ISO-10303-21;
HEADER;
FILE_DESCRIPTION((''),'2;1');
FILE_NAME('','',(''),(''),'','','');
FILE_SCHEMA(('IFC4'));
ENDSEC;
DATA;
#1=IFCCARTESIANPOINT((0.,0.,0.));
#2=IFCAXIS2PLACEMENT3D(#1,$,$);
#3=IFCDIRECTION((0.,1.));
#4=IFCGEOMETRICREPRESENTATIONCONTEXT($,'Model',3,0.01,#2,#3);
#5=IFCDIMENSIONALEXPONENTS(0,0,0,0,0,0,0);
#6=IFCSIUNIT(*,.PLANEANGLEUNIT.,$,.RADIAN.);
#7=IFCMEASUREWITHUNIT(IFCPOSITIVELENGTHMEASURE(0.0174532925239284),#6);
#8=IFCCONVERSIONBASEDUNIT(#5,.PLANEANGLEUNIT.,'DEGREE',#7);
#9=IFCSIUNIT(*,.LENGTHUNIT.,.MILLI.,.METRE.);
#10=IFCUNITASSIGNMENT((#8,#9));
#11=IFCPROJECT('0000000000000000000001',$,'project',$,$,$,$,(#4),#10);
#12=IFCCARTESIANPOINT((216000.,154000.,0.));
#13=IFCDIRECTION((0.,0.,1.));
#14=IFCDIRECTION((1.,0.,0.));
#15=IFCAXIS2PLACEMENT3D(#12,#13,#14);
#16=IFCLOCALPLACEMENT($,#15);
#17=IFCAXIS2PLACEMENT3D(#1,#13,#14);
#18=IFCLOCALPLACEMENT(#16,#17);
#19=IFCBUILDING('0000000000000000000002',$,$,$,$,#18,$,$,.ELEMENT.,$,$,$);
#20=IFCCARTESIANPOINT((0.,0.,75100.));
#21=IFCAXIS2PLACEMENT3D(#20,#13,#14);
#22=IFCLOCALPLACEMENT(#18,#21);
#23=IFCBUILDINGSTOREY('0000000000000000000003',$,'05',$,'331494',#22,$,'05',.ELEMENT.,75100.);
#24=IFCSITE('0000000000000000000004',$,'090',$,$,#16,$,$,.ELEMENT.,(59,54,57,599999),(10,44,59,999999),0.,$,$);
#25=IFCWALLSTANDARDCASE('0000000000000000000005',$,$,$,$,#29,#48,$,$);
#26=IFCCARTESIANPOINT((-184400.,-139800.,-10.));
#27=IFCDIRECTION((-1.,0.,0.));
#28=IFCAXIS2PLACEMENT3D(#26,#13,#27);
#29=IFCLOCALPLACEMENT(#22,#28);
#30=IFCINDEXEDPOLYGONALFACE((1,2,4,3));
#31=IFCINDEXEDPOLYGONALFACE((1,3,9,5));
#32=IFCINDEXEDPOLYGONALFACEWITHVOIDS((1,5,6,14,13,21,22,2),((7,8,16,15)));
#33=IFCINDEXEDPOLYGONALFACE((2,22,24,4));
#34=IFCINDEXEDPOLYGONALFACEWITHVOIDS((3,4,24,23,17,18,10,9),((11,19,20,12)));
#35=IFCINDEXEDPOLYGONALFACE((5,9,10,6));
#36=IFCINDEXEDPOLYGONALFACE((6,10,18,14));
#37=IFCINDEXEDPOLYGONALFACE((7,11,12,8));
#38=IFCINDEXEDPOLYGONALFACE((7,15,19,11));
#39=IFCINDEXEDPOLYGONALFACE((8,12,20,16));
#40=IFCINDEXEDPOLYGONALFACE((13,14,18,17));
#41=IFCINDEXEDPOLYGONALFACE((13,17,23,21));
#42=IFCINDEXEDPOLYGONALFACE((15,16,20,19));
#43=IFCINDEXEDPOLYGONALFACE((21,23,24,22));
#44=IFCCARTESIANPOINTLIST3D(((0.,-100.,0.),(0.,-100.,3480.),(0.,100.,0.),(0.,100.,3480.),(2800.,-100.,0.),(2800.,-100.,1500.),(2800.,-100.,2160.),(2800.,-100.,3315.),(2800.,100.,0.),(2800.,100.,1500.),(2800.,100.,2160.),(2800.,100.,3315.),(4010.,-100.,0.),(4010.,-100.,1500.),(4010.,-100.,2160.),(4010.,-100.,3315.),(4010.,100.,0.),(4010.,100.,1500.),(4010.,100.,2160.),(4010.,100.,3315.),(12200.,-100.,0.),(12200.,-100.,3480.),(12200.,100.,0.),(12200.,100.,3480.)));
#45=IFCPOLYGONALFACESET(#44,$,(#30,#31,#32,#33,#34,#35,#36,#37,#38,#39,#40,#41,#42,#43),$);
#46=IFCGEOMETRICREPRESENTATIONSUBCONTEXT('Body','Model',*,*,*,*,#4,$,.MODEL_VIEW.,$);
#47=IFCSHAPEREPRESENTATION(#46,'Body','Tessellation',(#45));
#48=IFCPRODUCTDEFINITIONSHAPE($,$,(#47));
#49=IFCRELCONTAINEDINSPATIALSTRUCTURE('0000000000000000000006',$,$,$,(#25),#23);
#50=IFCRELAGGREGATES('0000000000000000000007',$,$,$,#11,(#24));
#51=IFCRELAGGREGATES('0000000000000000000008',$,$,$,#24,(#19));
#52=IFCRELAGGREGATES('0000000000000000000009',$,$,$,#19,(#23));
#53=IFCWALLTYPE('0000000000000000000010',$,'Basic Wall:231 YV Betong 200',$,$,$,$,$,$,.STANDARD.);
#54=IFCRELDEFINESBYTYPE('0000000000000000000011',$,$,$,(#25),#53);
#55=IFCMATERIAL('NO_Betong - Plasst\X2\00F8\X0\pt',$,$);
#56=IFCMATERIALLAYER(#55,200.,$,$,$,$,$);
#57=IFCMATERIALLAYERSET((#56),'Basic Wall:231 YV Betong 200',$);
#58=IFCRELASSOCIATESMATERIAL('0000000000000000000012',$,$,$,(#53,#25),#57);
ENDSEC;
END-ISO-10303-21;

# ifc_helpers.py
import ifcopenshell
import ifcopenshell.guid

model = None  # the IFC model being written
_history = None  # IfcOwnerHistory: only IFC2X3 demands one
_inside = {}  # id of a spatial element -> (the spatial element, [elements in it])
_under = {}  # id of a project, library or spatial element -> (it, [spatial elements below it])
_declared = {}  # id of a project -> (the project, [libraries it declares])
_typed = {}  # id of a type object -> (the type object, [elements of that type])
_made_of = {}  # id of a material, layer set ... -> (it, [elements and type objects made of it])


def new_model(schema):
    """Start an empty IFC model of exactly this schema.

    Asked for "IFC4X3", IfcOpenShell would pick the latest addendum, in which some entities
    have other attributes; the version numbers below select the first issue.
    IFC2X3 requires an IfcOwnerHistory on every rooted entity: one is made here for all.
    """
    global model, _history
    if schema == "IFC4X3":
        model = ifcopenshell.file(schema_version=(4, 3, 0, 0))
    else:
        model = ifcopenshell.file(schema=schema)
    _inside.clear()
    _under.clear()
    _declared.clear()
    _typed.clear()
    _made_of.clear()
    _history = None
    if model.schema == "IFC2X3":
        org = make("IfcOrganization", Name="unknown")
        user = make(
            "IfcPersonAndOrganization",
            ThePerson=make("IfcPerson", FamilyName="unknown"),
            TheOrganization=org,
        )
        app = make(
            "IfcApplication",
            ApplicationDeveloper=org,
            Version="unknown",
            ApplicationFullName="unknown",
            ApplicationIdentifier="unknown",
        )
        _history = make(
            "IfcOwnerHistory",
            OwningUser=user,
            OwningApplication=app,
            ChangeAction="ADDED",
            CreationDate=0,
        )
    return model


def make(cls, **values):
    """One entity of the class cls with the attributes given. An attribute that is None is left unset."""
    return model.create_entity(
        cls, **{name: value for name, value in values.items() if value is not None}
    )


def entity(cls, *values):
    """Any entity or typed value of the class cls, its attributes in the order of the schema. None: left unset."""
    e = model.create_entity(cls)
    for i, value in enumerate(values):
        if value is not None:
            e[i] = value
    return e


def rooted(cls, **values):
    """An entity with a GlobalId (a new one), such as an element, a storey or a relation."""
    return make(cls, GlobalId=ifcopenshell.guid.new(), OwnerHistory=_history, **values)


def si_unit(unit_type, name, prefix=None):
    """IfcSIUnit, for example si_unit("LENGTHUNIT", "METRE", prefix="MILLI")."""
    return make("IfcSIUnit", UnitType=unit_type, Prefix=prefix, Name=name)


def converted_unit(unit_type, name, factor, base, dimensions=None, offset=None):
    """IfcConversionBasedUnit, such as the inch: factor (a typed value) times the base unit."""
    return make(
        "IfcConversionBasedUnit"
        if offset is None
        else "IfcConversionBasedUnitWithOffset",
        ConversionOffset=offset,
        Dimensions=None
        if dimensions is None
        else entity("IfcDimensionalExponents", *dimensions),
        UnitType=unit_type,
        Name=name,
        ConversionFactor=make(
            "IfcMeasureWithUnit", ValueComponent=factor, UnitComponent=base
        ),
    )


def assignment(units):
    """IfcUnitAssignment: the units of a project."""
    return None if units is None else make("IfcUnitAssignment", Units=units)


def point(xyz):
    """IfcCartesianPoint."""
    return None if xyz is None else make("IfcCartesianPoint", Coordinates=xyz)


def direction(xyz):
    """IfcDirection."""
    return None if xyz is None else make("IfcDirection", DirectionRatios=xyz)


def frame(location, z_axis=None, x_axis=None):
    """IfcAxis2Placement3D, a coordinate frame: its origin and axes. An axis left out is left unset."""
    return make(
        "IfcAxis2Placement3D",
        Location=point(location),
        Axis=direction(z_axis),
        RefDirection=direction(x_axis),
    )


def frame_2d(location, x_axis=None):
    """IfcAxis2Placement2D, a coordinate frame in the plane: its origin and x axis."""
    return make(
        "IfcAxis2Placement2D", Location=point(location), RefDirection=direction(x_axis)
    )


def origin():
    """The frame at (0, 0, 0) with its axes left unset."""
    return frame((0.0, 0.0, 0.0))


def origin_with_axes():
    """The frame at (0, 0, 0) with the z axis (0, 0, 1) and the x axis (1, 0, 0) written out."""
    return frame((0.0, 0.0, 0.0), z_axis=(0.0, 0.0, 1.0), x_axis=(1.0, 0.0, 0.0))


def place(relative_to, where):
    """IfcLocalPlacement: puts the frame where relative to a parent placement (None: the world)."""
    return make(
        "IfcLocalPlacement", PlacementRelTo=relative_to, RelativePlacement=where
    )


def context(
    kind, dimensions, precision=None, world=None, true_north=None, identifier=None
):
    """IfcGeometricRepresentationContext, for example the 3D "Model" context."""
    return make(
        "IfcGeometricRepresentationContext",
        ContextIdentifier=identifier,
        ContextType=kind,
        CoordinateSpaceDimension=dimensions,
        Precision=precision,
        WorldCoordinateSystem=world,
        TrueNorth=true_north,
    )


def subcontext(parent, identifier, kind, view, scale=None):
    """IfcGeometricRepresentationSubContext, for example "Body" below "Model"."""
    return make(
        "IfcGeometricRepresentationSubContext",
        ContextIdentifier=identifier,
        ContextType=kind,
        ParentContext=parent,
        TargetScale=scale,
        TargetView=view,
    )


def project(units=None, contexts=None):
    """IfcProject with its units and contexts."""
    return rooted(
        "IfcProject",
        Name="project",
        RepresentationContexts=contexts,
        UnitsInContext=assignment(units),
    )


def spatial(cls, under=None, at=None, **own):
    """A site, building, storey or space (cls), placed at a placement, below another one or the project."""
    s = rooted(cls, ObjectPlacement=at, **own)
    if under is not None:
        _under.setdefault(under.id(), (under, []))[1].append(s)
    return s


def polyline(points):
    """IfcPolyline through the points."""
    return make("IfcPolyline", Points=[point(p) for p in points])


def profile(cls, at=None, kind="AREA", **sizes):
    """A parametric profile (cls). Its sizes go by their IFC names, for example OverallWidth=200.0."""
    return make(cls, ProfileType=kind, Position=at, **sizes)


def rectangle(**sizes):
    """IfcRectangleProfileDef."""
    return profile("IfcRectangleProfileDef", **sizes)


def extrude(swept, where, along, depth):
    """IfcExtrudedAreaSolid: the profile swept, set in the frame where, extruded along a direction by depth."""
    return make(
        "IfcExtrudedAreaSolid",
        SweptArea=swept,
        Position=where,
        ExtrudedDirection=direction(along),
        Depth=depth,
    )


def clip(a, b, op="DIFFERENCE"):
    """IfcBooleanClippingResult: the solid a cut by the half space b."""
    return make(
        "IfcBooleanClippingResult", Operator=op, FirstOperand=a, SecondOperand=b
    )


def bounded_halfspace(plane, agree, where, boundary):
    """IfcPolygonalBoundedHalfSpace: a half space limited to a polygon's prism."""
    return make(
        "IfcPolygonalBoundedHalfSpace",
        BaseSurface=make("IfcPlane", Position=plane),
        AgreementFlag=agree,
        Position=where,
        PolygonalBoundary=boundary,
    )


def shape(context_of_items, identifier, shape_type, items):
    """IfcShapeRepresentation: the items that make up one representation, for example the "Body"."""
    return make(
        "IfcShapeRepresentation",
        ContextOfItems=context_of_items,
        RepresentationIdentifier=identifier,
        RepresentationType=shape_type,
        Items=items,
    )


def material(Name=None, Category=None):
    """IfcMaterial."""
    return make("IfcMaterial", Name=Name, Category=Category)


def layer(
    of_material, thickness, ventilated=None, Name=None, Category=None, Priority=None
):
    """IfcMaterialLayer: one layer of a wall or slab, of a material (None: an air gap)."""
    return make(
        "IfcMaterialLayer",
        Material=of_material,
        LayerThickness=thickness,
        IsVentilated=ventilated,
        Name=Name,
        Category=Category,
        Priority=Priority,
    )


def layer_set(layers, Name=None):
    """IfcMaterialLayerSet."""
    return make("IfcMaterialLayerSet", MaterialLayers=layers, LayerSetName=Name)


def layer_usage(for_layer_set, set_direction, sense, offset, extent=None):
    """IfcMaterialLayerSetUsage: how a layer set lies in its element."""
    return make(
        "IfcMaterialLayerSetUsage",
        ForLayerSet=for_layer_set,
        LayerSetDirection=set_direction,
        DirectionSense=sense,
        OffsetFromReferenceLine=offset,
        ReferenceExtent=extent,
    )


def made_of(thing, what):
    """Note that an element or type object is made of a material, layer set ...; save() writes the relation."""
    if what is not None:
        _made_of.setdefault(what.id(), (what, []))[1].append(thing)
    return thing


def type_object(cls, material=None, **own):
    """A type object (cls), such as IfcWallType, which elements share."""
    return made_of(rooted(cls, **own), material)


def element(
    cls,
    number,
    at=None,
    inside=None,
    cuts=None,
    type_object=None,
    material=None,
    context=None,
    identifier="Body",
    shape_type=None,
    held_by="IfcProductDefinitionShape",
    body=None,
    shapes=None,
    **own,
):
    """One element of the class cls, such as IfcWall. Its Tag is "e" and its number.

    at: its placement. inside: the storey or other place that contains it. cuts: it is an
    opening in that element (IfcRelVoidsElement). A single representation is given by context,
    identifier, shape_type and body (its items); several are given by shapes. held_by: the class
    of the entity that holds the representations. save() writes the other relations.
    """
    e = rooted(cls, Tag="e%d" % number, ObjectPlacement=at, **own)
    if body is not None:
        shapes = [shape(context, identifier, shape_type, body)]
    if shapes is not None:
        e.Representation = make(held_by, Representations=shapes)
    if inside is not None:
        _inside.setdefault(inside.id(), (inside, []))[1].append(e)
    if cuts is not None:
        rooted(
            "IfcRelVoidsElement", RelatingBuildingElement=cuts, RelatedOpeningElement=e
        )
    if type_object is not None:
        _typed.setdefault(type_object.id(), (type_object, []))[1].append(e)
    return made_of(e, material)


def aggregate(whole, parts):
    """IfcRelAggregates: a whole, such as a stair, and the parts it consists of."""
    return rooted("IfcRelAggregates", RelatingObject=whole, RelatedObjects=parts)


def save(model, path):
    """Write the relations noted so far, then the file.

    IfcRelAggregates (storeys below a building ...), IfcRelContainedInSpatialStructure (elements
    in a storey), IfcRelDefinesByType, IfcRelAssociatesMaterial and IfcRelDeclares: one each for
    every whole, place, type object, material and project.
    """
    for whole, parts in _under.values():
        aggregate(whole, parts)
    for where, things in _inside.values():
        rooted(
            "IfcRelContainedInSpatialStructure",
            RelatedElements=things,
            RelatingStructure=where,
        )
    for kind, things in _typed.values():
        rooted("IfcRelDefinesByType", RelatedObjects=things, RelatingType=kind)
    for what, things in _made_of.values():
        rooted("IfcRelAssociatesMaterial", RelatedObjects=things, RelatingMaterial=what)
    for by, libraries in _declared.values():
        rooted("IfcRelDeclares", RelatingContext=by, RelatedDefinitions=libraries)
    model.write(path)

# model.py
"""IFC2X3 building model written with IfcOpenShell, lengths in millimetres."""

from ifc_helpers import new_model, entity, si_unit, converted_unit, direction, frame, frame_2d, origin, origin_with_axes, place, context, subcontext, project, spatial, polyline, rectangle, extrude, clip, bounded_halfspace, material, layer, layer_set, layer_usage, type_object, element, save


model = new_model("IFC2X3")

# Units and contexts
model_context = context("Model", 3, precision=0.01, world=origin(), true_north=direction((0.0, 1.0)))
body_context = subcontext(model_context, "Body", "Model", "MODEL_VIEW")
ifc_project = project(units=[converted_unit("PLANEANGLEUNIT", "DEGREE", entity("IfcPositiveLengthMeasure", 0.0174532925239284), si_unit("PLANEANGLEUNIT", "RADIAN"), dimensions=[0, 0, 0, 0, 0, 0, 0]), si_unit("LENGTHUNIT", "METRE", prefix="MILLI")], contexts=[model_context])

# Site, building, storey
site_placement = place(None, frame((216000.0, 154000.0, 0.0), z_axis=(0.0, 0.0, 1.0), x_axis=(1.0, 0.0, 0.0)))
site = spatial("IfcSite", under=ifc_project, at=site_placement, Name="090", CompositionType="ELEMENT", RefLatitude=(59, 54, 57, 599999), RefLongitude=(10, 44, 59, 999999), RefElevation=0.0)
building_placement = place(site_placement, origin_with_axes())
building = spatial("IfcBuilding", under=site, at=building_placement, CompositionType="ELEMENT")
storey_placement = place(building_placement, frame((0.0, 0.0, 75100.0), z_axis=(0.0, 0.0, 1.0), x_axis=(1.0, 0.0, 0.0)))
storey = spatial("IfcBuildingStorey", under=building, at=storey_placement, Name="05", ObjectType="331494", LongName="05", CompositionType="ELEMENT", Elevation=75100.0)

# Wall, openings
ifc_material = material(Name="NO_Betong - Plasstøpt")
ifc_layer = layer(ifc_material, 200.0)
ifc_layer_set = layer_set([ifc_layer], Name="Basic Wall:231 YV Betong 200")
ifc_layer_usage = layer_usage(ifc_layer_set, "AXIS2", "NEGATIVE", 100.0)
wall_type = type_object("IfcWallType", Name="Basic Wall:231 YV Betong 200", PredefinedType="STANDARD", material=ifc_layer_set)
wall_placement = place(storey_placement, frame((-184400.0, -139800.0, -10.0), z_axis=(0.0, 0.0, 1.0), x_axis=(-1.0, 0.0, 0.0)))
wall = element("IfcWallStandardCase", 1, at=wall_placement, inside=storey, type_object=wall_type, material=ifc_layer_usage, context=body_context, shape_type="Clipping", body=[
    clip(clip(extrude(rectangle(XDim=12200.0, YDim=200.0, at=frame_2d((6100.0, 0.0), x_axis=(-1.0, 0.0))), origin(), (0.0, 0.0, 1.0), 3480.0), bounded_halfspace(frame((9400.0, -100.0, 3480.0), z_axis=(0.0, 0.0, -1.0), x_axis=(-1.0, 0.0, 0.0)), True, frame((9400.0, -100.0, 3480.0)), polyline([(0.0, 0.0), (2800.0, 0.0), (2800.0, 200.0), (0.0, 200.0), (0.0, 0.0)]))), bounded_halfspace(frame((0.0, -100.0, 3480.0), z_axis=(0.0, 0.0, -1.0), x_axis=(-1.0, 0.0, 0.0)), True, frame((0.0, -100.0, 3480.0)), polyline([(0.0, 0.0), (2600.0, 0.0), (2600.0, 200.0), (0.0, 200.0), (0.0, 0.0)]))),
])
opening_1_placement = place(wall_placement, origin_with_axes())
element("IfcOpeningElement", 2, at=opening_1_placement, cuts=wall, ObjectType="Opening", context=body_context, shape_type="SweptSolid", body=[
    extrude(rectangle(XDim=1525.0, YDim=1210.0, at=frame_2d((0.0, 0.0), x_axis=(0.0, 1.0))), frame((3405.0, -1624.0, 737.5), z_axis=(0.0, 1.0, 0.0), x_axis=(1.0, 0.0, 0.0)), (0.0, 0.0, 1.0), 3048.0),
])
opening_2_placement = place(wall_placement, origin_with_axes())
element("IfcOpeningElement", 3, at=opening_2_placement, cuts=wall, ObjectType="Opening", context=body_context, shape_type="SweptSolid", body=[
    extrude(rectangle(XDim=1155.0, YDim=1210.0, at=frame_2d((0.0, 0.0), x_axis=(0.0, 1.0))), frame((3405.0, -1624.0, 2737.5), z_axis=(0.0, 1.0, 0.0), x_axis=(1.0, 0.0, 0.0)), (0.0, 0.0, 1.0), 3048.0),
])

save(model, "model.ifc")
